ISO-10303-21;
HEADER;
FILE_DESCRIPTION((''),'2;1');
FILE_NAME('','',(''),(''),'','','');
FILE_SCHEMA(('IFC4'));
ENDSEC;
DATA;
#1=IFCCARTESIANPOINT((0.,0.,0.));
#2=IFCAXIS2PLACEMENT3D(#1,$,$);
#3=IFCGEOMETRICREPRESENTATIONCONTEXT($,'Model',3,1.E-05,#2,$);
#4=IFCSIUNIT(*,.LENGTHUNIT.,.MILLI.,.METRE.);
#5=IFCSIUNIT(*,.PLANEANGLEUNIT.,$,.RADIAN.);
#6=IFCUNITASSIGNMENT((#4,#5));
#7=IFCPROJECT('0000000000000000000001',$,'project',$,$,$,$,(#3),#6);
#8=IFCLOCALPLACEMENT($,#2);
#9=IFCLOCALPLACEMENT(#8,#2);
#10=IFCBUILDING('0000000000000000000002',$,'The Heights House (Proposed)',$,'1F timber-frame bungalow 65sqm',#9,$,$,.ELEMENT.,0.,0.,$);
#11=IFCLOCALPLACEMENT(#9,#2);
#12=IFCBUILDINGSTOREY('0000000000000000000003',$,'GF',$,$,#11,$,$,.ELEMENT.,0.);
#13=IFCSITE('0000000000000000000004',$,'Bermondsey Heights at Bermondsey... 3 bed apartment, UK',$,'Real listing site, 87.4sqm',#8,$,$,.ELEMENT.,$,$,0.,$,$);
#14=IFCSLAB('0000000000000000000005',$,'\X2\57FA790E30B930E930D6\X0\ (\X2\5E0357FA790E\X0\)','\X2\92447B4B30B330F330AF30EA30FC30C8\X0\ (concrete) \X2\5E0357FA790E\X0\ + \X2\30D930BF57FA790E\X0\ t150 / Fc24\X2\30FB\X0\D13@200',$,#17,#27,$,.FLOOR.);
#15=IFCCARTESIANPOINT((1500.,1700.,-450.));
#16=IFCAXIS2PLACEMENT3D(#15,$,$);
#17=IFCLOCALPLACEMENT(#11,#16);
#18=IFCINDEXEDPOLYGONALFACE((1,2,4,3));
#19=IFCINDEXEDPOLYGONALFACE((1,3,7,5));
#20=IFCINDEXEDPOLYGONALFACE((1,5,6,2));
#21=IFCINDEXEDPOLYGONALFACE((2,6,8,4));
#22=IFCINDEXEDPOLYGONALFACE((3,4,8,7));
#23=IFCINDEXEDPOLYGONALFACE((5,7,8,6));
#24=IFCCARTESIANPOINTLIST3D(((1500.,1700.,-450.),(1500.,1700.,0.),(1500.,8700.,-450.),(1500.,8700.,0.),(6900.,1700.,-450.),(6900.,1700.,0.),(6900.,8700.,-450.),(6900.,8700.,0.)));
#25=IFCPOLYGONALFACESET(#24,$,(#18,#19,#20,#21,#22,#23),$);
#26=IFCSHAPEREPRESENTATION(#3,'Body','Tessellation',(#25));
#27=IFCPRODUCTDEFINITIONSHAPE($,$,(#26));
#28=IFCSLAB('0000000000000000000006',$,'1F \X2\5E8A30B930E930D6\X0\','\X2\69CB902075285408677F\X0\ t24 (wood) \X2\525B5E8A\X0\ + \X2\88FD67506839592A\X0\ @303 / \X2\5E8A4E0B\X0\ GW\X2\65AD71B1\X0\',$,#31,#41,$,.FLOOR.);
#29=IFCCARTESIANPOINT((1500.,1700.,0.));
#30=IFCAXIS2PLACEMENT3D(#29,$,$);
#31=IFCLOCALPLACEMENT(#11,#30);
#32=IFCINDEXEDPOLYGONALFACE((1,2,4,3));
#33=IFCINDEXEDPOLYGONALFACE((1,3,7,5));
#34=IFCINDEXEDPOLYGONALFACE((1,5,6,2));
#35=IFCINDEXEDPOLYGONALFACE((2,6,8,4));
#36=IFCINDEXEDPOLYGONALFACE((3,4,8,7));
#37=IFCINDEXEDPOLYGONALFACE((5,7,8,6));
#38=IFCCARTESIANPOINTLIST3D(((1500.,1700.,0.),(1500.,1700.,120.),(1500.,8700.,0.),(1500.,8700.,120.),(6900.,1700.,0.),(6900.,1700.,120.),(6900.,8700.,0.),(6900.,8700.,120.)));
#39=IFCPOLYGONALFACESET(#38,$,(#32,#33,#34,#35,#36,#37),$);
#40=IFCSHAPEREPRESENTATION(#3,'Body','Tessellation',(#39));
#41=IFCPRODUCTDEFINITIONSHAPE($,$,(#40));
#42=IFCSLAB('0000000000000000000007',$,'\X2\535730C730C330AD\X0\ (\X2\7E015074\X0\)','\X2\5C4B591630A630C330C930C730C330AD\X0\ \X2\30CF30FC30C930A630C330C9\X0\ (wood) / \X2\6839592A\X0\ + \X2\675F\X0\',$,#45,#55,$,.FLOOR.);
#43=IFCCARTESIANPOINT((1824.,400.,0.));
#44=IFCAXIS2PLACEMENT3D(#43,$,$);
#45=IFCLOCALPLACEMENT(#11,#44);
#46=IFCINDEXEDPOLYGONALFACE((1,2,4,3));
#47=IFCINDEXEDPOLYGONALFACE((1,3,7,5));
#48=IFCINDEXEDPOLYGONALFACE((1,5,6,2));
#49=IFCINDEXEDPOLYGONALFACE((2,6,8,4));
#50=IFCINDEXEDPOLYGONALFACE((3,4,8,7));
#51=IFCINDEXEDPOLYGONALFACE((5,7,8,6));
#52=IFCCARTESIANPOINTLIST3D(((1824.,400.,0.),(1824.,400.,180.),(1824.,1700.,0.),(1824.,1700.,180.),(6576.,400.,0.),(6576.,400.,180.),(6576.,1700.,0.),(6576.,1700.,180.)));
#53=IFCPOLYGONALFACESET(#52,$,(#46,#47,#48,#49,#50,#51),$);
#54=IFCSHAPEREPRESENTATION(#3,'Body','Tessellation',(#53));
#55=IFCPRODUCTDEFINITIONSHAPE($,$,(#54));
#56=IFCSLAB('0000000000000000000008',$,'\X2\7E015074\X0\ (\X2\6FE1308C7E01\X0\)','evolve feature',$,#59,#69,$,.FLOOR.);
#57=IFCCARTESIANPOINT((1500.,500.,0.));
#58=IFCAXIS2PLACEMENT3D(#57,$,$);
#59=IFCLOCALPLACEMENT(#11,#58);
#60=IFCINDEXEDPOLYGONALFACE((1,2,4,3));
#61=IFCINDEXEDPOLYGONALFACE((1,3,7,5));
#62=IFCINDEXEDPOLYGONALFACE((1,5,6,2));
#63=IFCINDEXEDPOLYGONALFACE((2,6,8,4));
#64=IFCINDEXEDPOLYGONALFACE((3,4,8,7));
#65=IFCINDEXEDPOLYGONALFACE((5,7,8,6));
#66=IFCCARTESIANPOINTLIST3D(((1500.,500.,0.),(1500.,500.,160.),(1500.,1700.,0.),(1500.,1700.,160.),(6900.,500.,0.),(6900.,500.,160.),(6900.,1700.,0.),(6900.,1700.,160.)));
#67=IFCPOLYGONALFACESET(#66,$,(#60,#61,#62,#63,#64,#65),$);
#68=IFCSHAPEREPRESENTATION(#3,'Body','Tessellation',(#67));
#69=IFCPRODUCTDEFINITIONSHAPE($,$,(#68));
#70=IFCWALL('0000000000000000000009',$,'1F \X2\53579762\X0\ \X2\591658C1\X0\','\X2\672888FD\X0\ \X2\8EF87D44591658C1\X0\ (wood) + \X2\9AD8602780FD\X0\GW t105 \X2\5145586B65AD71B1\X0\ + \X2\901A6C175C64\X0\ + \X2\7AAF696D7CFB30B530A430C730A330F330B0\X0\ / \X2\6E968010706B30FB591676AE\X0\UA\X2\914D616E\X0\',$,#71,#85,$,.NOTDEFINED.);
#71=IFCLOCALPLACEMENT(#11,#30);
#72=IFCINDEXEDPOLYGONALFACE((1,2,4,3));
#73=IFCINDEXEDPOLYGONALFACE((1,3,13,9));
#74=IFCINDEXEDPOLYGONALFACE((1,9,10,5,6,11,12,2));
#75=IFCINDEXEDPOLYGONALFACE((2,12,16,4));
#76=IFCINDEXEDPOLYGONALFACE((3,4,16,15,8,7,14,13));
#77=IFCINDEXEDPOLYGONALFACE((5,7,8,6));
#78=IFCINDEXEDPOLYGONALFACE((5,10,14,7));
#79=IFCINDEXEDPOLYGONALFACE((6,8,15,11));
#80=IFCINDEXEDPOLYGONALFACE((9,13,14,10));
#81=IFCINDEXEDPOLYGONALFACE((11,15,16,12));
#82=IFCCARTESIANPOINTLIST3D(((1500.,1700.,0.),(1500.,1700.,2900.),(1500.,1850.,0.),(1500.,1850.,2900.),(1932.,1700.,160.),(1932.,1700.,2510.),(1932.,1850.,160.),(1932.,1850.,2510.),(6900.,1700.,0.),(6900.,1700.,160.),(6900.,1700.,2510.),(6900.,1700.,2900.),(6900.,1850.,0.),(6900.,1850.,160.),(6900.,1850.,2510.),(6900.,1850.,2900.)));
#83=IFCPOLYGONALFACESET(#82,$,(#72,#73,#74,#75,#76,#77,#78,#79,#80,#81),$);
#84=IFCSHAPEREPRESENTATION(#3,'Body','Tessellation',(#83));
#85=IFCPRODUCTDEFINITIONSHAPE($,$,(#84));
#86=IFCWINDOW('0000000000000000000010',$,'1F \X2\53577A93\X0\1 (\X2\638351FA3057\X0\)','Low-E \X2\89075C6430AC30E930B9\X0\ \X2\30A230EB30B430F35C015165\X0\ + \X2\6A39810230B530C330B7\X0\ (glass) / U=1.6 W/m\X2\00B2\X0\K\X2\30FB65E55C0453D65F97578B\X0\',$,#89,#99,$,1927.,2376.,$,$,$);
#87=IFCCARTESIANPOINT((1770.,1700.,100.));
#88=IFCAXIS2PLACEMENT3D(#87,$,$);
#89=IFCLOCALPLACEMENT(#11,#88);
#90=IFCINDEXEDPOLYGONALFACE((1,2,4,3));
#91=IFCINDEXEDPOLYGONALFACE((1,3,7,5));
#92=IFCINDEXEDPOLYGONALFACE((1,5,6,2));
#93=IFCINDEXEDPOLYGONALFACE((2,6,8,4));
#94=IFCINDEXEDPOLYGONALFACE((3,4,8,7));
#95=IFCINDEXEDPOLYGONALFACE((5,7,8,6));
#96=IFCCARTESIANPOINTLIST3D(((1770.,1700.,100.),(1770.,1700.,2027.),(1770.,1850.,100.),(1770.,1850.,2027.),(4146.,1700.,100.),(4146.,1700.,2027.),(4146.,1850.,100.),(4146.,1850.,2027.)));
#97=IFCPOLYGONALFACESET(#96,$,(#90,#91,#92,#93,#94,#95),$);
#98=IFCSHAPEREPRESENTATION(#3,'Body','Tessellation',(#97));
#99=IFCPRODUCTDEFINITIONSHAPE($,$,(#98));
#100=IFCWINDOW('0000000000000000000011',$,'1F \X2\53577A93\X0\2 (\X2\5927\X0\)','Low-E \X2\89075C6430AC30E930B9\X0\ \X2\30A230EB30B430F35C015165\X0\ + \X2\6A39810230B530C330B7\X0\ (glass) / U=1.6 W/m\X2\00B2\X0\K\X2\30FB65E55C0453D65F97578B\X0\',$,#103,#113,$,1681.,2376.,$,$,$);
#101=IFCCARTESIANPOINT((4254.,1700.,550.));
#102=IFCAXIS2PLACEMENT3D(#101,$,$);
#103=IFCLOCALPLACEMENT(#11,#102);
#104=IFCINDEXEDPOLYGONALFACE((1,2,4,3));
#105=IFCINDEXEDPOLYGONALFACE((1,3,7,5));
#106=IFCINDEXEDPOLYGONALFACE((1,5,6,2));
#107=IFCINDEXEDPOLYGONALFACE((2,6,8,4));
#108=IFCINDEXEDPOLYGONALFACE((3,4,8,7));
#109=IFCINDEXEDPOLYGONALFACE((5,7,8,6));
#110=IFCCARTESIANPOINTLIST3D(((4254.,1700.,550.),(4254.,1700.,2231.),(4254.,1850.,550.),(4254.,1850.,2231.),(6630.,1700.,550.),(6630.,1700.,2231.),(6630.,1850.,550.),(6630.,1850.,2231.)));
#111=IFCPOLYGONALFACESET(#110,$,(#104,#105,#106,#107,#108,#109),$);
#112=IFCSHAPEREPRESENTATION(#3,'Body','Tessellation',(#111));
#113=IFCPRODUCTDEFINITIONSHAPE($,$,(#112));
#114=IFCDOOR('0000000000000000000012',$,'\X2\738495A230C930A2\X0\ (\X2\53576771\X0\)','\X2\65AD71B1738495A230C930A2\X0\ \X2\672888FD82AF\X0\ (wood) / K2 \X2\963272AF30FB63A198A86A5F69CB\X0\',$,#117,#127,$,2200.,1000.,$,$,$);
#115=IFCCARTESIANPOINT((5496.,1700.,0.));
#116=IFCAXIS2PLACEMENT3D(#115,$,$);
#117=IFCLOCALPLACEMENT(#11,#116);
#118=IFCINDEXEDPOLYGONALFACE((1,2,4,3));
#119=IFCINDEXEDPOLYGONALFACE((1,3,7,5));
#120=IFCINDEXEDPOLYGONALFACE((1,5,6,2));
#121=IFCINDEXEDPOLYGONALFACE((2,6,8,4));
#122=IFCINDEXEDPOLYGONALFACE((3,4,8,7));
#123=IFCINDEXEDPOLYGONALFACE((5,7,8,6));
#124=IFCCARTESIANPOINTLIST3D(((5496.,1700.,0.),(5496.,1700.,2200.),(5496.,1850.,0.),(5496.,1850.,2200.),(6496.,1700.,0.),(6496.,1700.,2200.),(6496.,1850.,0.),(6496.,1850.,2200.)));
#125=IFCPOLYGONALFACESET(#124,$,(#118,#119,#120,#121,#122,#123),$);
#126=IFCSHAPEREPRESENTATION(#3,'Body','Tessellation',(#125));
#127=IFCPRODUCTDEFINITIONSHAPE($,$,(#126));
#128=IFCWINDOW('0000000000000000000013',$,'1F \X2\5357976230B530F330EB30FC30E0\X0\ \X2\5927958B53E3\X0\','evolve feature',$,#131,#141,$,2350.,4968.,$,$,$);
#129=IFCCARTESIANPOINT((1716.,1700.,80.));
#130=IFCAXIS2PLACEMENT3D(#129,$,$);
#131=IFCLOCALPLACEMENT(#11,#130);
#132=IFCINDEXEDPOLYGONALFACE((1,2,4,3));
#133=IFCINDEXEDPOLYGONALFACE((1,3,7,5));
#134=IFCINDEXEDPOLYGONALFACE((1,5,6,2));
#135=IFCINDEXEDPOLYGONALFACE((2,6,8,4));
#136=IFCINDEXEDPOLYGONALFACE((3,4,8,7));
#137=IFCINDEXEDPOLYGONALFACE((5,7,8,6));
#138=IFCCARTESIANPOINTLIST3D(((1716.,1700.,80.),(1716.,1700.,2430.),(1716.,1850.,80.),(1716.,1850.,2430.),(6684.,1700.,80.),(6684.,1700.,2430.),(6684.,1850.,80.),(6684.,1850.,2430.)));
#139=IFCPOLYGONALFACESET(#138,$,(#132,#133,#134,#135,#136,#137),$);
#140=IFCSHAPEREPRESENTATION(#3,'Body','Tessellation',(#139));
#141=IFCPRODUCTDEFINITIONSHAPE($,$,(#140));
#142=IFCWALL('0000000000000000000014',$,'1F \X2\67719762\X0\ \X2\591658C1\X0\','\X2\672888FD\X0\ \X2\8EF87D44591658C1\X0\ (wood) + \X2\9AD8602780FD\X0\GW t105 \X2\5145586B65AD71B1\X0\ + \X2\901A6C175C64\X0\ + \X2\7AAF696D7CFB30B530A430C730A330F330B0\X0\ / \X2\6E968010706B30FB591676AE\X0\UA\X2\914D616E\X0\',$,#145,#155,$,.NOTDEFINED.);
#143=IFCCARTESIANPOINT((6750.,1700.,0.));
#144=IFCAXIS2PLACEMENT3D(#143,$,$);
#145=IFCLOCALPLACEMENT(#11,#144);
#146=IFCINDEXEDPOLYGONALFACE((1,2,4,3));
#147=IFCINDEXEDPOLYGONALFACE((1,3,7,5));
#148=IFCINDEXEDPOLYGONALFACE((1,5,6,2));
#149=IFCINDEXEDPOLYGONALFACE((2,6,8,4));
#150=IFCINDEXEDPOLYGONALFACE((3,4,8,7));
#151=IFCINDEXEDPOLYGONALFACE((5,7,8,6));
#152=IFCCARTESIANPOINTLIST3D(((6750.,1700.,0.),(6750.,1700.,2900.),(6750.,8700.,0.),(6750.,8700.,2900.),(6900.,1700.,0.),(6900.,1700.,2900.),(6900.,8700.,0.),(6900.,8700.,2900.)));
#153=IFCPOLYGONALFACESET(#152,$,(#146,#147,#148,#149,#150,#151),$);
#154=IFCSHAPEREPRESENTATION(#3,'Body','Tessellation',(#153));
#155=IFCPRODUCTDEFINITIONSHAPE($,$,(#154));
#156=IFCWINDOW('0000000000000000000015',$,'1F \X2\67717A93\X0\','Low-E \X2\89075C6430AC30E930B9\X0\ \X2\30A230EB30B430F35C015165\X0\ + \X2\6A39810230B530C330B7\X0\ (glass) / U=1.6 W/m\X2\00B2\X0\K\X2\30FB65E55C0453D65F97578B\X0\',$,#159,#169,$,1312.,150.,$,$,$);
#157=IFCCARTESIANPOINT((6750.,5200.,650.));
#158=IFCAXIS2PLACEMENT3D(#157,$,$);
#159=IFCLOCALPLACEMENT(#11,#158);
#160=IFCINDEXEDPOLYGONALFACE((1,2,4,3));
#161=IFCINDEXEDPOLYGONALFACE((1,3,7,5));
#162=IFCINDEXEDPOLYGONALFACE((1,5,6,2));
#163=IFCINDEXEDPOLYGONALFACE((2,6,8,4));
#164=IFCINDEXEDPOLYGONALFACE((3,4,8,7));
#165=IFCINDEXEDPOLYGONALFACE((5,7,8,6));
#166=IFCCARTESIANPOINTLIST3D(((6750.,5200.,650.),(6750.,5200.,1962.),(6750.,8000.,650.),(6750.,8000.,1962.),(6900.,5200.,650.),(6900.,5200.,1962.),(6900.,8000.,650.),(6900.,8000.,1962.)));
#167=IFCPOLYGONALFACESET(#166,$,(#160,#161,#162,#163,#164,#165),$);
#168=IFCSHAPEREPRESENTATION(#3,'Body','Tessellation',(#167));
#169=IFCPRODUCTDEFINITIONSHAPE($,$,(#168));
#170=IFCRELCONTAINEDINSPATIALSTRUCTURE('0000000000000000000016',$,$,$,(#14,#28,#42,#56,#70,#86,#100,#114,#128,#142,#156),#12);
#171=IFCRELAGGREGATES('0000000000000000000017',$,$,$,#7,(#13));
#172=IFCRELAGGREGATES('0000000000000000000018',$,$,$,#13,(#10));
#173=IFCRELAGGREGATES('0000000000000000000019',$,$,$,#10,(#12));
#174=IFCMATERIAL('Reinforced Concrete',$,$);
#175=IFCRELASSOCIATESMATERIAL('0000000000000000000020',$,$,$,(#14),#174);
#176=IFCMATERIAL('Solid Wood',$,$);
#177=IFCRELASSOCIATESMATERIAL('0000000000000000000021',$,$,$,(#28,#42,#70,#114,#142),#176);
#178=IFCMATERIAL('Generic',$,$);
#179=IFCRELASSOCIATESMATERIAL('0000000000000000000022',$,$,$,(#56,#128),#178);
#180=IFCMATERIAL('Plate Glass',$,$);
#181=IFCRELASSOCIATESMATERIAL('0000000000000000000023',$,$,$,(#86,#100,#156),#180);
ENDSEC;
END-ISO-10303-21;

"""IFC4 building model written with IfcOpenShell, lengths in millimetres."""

from ifc_helpers import new_model, si_unit, frame, frame_2d, origin, place, context, project, spatial, rectangle, extrude, material, element, fill, save


model = new_model("IFC4")

# Units and contexts
model_context = context("Model", 3, precision=1e-05, world=origin())
ifc_project = project(units=[si_unit("LENGTHUNIT", "METRE", prefix="MILLI"), si_unit("PLANEANGLEUNIT", "RADIAN")], contexts=[model_context])

# Site, building, storey
site_placement = place(None, origin())
site = spatial("IfcSite", under=ifc_project, at=site_placement, Name="Bermondsey Heights at Bermondsey... 3 bed apartment, UK", ObjectType="Real listing site, 87.4sqm", CompositionType="ELEMENT", RefElevation=0.0)
building_placement = place(site_placement, origin())
building = spatial("IfcBuilding", under=site, at=building_placement, Name="The Heights House (Proposed)", ObjectType="1F timber-frame bungalow 65sqm", CompositionType="ELEMENT", ElevationOfRefHeight=0.0, ElevationOfTerrain=0.0)
storey_placement = place(building_placement, origin())
storey = spatial("IfcBuildingStorey", under=building, at=storey_placement, Name="GF", CompositionType="ELEMENT", Elevation=0.0)

# Slabs
ifc_material_1 = material(Name="Reinforced Concrete")
slab_1_placement = place(storey_placement, frame((1500.0, 1700.0, -450.0)))
element("IfcSlab", 1, at=slab_1_placement, inside=storey, material=ifc_material_1, Name="基礎スラブ (布基礎)", Description="鉄筋コンクリート (concrete) 布基礎 + ベタ基礎 t150 / Fc24・D13@200", PredefinedType="FLOOR", context=model_context, shape_type="SweptSolid", body=[
    extrude(rectangle(XDim=5400.0, YDim=7000.0, at=frame_2d((2700.0, 3500.0))), frame((1500.0, 1700.0, -450.0)), (0.0, 0.0, 1.0), 450.0),
])
ifc_material_2 = material(Name="Solid Wood")
slab_2_placement = place(storey_placement, frame((1500.0, 1700.0, 0.0)))
element("IfcSlab", 2, at=slab_2_placement, inside=storey, material=ifc_material_2, Name="1F 床スラブ", Description="構造用合板 t24 (wood) 剛床 + 製材根太 @303 / 床下 GW断熱", PredefinedType="FLOOR", context=model_context, shape_type="SweptSolid", body=[
    extrude(rectangle(XDim=5400.0, YDim=7000.0, at=frame_2d((2700.0, 3500.0))), frame((1500.0, 1700.0, 0.0)), (0.0, 0.0, 1.0), 120.0),
])
slab_3_placement = place(storey_placement, frame((1824.0, 400.0, 0.0)))
element("IfcSlab", 3, at=slab_3_placement, inside=storey, material=ifc_material_2, Name="南デッキ (縁側)", Description="屋外ウッドデッキ ハードウッド (wood) / 根太 + 束", PredefinedType="FLOOR", context=model_context, shape_type="SweptSolid", body=[
    extrude(rectangle(XDim=4752.0, YDim=1300.0, at=frame_2d((2376.0, 650.0))), frame((1824.0, 400.0, 0.0)), (0.0, 0.0, 1.0), 180.0),
])
ifc_material_3 = material(Name="Generic")
slab_4_placement = place(storey_placement, frame((1500.0, 500.0, 0.0)))
element("IfcSlab", 4, at=slab_4_placement, inside=storey, material=ifc_material_3, Name="縁側 (濡れ縁)", Description="evolve feature", PredefinedType="FLOOR", context=model_context, shape_type="SweptSolid", body=[
    extrude(rectangle(XDim=5400.0, YDim=1200.0, at=frame_2d((2700.0, 600.0))), frame((1500.0, 500.0, 0.0)), (0.0, 0.0, 1.0), 160.0),
])

# Wall, openings, windows, door
wall_1_placement = place(storey_placement, frame((1500.0, 1700.0, 0.0)))
wall_1 = element("IfcWall", 5, at=wall_1_placement, inside=storey, material=ifc_material_2, Name="1F 南面 外壁", Description="木製 軸組外壁 (wood) + 高性能GW t105 充填断熱 + 通気層 + 窯業系サイディング / 準耐火・外皮UA配慮", PredefinedType="NOTDEFINED", context=model_context, shape_type="SweptSolid", body=[
    extrude(rectangle(XDim=5400.0, YDim=150.0, at=frame_2d((2700.0, 75.0))), frame((1500.0, 1700.0, 0.0)), (0.0, 0.0, 1.0), 2900.0),
])
opening_1_placement = place(storey_placement, frame((1770.0, 1700.0, 100.0)))
opening_1 = element("IfcOpeningElement", 6, at=opening_1_placement, cuts=wall_1, PredefinedType="NOTDEFINED", context=model_context, shape_type="SweptSolid", body=[
    extrude(rectangle(XDim=2376.0, YDim=150.0, at=frame_2d((1188.0, 75.0))), frame((1770.0, 1700.0, 100.0)), (0.0, 0.0, 1.0), 1927.0),
])
opening_2_placement = place(storey_placement, frame((4254.0, 1700.0, 550.0)))
opening_2 = element("IfcOpeningElement", 7, at=opening_2_placement, cuts=wall_1, PredefinedType="NOTDEFINED", context=model_context, shape_type="SweptSolid", body=[
    extrude(rectangle(XDim=2376.0, YDim=150.0, at=frame_2d((1188.0, 75.0))), frame((4254.0, 1700.0, 550.0)), (0.0, 0.0, 1.0), 1681.0),
])
opening_3_placement = place(storey_placement, frame((5496.0, 1700.0, 0.0)))
opening_3 = element("IfcOpeningElement", 8, at=opening_3_placement, cuts=wall_1, PredefinedType="NOTDEFINED", context=model_context, shape_type="SweptSolid", body=[
    extrude(rectangle(XDim=1000.0, YDim=150.0, at=frame_2d((500.0, 75.0))), frame((5496.0, 1700.0, 0.0)), (0.0, 0.0, 1.0), 2200.0),
])
opening_4_placement = place(storey_placement, frame((1716.0, 1700.0, 80.0)))
opening_4 = element("IfcOpeningElement", 9, at=opening_4_placement, cuts=wall_1, PredefinedType="NOTDEFINED", context=model_context, shape_type="SweptSolid", body=[
    extrude(rectangle(XDim=4968.0, YDim=150.0, at=frame_2d((2484.0, 75.0))), frame((1716.0, 1700.0, 80.0)), (0.0, 0.0, 1.0), 2350.0),
])
ifc_material_4 = material(Name="Plate Glass")
window_1_placement = place(storey_placement, frame((1770.0, 1700.0, 100.0)))
window_1 = element("IfcWindow", 10, at=window_1_placement, inside=storey, material=ifc_material_4, Name="1F 南窓1 (掃出し)", Description="Low-E 複層ガラス アルゴン封入 + 樹脂サッシ (glass) / U=1.6 W/m²K・日射取得型", OverallHeight=1927.0, OverallWidth=2376.0, context=model_context, shape_type="SweptSolid", body=[
    extrude(rectangle(XDim=2376.0, YDim=150.0, at=frame_2d((1188.0, 75.0))), frame((1770.0, 1700.0, 100.0)), (0.0, 0.0, 1.0), 1927.0),
])
fill(opening_1, window_1)
window_2_placement = place(storey_placement, frame((4254.0, 1700.0, 550.0)))
window_2 = element("IfcWindow", 11, at=window_2_placement, inside=storey, material=ifc_material_4, Name="1F 南窓2 (大)", Description="Low-E 複層ガラス アルゴン封入 + 樹脂サッシ (glass) / U=1.6 W/m²K・日射取得型", OverallHeight=1681.0, OverallWidth=2376.0, context=model_context, shape_type="SweptSolid", body=[
    extrude(rectangle(XDim=2376.0, YDim=150.0, at=frame_2d((1188.0, 75.0))), frame((4254.0, 1700.0, 550.0)), (0.0, 0.0, 1.0), 1681.0),
])
fill(opening_2, window_2)
door_placement = place(storey_placement, frame((5496.0, 1700.0, 0.0)))
door = element("IfcDoor", 12, at=door_placement, inside=storey, material=ifc_material_2, Name="玄関ドア (南東)", Description="断熱玄関ドア 木製芯 (wood) / K2 防犯・採風機構", OverallHeight=2200.0, OverallWidth=1000.0, context=model_context, shape_type="SweptSolid", body=[
    extrude(rectangle(XDim=1000.0, YDim=150.0, at=frame_2d((500.0, 75.0))), frame((5496.0, 1700.0, 0.0)), (0.0, 0.0, 1.0), 2200.0),
])
fill(opening_3, door)
window_3_placement = place(storey_placement, frame((1716.0, 1700.0, 80.0)))
window_3 = element("IfcWindow", 13, at=window_3_placement, inside=storey, material=ifc_material_3, Name="1F 南面サンルーム 大開口", Description="evolve feature", OverallHeight=2350.0, OverallWidth=4968.0, context=model_context, shape_type="SweptSolid", body=[
    extrude(rectangle(XDim=4968.0, YDim=150.0, at=frame_2d((2484.0, 75.0))), frame((1716.0, 1700.0, 80.0)), (0.0, 0.0, 1.0), 2350.0),
])
fill(opening_4, window_3)

# Wall, opening, window
wall_2_placement = place(storey_placement, frame((6750.0, 1700.0, 0.0)))
wall_2 = element("IfcWall", 14, at=wall_2_placement, inside=storey, material=ifc_material_2, Name="1F 東面 外壁", Description="木製 軸組外壁 (wood) + 高性能GW t105 充填断熱 + 通気層 + 窯業系サイディング / 準耐火・外皮UA配慮", PredefinedType="NOTDEFINED", context=model_context, shape_type="SweptSolid", body=[
    extrude(rectangle(XDim=150.0, YDim=7000.0, at=frame_2d((75.0, 3500.0))), frame((6750.0, 1700.0, 0.0)), (0.0, 0.0, 1.0), 2900.0),
])
opening_5_placement = place(storey_placement, frame((6750.0, 5200.0, 650.0)))
opening_5 = element("IfcOpeningElement", 15, at=opening_5_placement, cuts=wall_2, PredefinedType="NOTDEFINED", context=model_context, shape_type="SweptSolid", body=[
    extrude(rectangle(XDim=150.0, YDim=2800.0, at=frame_2d((75.0, 1400.0))), frame((6750.0, 5200.0, 650.0)), (0.0, 0.0, 1.0), 1312.0),
])
window_4_placement = place(storey_placement, frame((6750.0, 5200.0, 650.0)))
window_4 = element("IfcWindow", 16, at=window_4_placement, inside=storey, material=ifc_material_4, Name="1F 東窓", Description="Low-E 複層ガラス アルゴン封入 + 樹脂サッシ (glass) / U=1.6 W/m²K・日射取得型", OverallHeight=1312.0, OverallWidth=150.0, context=model_context, shape_type="SweptSolid", body=[
    extrude(rectangle(XDim=150.0, YDim=2800.0, at=frame_2d((75.0, 1400.0))), frame((6750.0, 5200.0, 650.0)), (0.0, 0.0, 1.0), 1312.0),
])
fill(opening_5, window_4)

save(model, "model.ifc")
